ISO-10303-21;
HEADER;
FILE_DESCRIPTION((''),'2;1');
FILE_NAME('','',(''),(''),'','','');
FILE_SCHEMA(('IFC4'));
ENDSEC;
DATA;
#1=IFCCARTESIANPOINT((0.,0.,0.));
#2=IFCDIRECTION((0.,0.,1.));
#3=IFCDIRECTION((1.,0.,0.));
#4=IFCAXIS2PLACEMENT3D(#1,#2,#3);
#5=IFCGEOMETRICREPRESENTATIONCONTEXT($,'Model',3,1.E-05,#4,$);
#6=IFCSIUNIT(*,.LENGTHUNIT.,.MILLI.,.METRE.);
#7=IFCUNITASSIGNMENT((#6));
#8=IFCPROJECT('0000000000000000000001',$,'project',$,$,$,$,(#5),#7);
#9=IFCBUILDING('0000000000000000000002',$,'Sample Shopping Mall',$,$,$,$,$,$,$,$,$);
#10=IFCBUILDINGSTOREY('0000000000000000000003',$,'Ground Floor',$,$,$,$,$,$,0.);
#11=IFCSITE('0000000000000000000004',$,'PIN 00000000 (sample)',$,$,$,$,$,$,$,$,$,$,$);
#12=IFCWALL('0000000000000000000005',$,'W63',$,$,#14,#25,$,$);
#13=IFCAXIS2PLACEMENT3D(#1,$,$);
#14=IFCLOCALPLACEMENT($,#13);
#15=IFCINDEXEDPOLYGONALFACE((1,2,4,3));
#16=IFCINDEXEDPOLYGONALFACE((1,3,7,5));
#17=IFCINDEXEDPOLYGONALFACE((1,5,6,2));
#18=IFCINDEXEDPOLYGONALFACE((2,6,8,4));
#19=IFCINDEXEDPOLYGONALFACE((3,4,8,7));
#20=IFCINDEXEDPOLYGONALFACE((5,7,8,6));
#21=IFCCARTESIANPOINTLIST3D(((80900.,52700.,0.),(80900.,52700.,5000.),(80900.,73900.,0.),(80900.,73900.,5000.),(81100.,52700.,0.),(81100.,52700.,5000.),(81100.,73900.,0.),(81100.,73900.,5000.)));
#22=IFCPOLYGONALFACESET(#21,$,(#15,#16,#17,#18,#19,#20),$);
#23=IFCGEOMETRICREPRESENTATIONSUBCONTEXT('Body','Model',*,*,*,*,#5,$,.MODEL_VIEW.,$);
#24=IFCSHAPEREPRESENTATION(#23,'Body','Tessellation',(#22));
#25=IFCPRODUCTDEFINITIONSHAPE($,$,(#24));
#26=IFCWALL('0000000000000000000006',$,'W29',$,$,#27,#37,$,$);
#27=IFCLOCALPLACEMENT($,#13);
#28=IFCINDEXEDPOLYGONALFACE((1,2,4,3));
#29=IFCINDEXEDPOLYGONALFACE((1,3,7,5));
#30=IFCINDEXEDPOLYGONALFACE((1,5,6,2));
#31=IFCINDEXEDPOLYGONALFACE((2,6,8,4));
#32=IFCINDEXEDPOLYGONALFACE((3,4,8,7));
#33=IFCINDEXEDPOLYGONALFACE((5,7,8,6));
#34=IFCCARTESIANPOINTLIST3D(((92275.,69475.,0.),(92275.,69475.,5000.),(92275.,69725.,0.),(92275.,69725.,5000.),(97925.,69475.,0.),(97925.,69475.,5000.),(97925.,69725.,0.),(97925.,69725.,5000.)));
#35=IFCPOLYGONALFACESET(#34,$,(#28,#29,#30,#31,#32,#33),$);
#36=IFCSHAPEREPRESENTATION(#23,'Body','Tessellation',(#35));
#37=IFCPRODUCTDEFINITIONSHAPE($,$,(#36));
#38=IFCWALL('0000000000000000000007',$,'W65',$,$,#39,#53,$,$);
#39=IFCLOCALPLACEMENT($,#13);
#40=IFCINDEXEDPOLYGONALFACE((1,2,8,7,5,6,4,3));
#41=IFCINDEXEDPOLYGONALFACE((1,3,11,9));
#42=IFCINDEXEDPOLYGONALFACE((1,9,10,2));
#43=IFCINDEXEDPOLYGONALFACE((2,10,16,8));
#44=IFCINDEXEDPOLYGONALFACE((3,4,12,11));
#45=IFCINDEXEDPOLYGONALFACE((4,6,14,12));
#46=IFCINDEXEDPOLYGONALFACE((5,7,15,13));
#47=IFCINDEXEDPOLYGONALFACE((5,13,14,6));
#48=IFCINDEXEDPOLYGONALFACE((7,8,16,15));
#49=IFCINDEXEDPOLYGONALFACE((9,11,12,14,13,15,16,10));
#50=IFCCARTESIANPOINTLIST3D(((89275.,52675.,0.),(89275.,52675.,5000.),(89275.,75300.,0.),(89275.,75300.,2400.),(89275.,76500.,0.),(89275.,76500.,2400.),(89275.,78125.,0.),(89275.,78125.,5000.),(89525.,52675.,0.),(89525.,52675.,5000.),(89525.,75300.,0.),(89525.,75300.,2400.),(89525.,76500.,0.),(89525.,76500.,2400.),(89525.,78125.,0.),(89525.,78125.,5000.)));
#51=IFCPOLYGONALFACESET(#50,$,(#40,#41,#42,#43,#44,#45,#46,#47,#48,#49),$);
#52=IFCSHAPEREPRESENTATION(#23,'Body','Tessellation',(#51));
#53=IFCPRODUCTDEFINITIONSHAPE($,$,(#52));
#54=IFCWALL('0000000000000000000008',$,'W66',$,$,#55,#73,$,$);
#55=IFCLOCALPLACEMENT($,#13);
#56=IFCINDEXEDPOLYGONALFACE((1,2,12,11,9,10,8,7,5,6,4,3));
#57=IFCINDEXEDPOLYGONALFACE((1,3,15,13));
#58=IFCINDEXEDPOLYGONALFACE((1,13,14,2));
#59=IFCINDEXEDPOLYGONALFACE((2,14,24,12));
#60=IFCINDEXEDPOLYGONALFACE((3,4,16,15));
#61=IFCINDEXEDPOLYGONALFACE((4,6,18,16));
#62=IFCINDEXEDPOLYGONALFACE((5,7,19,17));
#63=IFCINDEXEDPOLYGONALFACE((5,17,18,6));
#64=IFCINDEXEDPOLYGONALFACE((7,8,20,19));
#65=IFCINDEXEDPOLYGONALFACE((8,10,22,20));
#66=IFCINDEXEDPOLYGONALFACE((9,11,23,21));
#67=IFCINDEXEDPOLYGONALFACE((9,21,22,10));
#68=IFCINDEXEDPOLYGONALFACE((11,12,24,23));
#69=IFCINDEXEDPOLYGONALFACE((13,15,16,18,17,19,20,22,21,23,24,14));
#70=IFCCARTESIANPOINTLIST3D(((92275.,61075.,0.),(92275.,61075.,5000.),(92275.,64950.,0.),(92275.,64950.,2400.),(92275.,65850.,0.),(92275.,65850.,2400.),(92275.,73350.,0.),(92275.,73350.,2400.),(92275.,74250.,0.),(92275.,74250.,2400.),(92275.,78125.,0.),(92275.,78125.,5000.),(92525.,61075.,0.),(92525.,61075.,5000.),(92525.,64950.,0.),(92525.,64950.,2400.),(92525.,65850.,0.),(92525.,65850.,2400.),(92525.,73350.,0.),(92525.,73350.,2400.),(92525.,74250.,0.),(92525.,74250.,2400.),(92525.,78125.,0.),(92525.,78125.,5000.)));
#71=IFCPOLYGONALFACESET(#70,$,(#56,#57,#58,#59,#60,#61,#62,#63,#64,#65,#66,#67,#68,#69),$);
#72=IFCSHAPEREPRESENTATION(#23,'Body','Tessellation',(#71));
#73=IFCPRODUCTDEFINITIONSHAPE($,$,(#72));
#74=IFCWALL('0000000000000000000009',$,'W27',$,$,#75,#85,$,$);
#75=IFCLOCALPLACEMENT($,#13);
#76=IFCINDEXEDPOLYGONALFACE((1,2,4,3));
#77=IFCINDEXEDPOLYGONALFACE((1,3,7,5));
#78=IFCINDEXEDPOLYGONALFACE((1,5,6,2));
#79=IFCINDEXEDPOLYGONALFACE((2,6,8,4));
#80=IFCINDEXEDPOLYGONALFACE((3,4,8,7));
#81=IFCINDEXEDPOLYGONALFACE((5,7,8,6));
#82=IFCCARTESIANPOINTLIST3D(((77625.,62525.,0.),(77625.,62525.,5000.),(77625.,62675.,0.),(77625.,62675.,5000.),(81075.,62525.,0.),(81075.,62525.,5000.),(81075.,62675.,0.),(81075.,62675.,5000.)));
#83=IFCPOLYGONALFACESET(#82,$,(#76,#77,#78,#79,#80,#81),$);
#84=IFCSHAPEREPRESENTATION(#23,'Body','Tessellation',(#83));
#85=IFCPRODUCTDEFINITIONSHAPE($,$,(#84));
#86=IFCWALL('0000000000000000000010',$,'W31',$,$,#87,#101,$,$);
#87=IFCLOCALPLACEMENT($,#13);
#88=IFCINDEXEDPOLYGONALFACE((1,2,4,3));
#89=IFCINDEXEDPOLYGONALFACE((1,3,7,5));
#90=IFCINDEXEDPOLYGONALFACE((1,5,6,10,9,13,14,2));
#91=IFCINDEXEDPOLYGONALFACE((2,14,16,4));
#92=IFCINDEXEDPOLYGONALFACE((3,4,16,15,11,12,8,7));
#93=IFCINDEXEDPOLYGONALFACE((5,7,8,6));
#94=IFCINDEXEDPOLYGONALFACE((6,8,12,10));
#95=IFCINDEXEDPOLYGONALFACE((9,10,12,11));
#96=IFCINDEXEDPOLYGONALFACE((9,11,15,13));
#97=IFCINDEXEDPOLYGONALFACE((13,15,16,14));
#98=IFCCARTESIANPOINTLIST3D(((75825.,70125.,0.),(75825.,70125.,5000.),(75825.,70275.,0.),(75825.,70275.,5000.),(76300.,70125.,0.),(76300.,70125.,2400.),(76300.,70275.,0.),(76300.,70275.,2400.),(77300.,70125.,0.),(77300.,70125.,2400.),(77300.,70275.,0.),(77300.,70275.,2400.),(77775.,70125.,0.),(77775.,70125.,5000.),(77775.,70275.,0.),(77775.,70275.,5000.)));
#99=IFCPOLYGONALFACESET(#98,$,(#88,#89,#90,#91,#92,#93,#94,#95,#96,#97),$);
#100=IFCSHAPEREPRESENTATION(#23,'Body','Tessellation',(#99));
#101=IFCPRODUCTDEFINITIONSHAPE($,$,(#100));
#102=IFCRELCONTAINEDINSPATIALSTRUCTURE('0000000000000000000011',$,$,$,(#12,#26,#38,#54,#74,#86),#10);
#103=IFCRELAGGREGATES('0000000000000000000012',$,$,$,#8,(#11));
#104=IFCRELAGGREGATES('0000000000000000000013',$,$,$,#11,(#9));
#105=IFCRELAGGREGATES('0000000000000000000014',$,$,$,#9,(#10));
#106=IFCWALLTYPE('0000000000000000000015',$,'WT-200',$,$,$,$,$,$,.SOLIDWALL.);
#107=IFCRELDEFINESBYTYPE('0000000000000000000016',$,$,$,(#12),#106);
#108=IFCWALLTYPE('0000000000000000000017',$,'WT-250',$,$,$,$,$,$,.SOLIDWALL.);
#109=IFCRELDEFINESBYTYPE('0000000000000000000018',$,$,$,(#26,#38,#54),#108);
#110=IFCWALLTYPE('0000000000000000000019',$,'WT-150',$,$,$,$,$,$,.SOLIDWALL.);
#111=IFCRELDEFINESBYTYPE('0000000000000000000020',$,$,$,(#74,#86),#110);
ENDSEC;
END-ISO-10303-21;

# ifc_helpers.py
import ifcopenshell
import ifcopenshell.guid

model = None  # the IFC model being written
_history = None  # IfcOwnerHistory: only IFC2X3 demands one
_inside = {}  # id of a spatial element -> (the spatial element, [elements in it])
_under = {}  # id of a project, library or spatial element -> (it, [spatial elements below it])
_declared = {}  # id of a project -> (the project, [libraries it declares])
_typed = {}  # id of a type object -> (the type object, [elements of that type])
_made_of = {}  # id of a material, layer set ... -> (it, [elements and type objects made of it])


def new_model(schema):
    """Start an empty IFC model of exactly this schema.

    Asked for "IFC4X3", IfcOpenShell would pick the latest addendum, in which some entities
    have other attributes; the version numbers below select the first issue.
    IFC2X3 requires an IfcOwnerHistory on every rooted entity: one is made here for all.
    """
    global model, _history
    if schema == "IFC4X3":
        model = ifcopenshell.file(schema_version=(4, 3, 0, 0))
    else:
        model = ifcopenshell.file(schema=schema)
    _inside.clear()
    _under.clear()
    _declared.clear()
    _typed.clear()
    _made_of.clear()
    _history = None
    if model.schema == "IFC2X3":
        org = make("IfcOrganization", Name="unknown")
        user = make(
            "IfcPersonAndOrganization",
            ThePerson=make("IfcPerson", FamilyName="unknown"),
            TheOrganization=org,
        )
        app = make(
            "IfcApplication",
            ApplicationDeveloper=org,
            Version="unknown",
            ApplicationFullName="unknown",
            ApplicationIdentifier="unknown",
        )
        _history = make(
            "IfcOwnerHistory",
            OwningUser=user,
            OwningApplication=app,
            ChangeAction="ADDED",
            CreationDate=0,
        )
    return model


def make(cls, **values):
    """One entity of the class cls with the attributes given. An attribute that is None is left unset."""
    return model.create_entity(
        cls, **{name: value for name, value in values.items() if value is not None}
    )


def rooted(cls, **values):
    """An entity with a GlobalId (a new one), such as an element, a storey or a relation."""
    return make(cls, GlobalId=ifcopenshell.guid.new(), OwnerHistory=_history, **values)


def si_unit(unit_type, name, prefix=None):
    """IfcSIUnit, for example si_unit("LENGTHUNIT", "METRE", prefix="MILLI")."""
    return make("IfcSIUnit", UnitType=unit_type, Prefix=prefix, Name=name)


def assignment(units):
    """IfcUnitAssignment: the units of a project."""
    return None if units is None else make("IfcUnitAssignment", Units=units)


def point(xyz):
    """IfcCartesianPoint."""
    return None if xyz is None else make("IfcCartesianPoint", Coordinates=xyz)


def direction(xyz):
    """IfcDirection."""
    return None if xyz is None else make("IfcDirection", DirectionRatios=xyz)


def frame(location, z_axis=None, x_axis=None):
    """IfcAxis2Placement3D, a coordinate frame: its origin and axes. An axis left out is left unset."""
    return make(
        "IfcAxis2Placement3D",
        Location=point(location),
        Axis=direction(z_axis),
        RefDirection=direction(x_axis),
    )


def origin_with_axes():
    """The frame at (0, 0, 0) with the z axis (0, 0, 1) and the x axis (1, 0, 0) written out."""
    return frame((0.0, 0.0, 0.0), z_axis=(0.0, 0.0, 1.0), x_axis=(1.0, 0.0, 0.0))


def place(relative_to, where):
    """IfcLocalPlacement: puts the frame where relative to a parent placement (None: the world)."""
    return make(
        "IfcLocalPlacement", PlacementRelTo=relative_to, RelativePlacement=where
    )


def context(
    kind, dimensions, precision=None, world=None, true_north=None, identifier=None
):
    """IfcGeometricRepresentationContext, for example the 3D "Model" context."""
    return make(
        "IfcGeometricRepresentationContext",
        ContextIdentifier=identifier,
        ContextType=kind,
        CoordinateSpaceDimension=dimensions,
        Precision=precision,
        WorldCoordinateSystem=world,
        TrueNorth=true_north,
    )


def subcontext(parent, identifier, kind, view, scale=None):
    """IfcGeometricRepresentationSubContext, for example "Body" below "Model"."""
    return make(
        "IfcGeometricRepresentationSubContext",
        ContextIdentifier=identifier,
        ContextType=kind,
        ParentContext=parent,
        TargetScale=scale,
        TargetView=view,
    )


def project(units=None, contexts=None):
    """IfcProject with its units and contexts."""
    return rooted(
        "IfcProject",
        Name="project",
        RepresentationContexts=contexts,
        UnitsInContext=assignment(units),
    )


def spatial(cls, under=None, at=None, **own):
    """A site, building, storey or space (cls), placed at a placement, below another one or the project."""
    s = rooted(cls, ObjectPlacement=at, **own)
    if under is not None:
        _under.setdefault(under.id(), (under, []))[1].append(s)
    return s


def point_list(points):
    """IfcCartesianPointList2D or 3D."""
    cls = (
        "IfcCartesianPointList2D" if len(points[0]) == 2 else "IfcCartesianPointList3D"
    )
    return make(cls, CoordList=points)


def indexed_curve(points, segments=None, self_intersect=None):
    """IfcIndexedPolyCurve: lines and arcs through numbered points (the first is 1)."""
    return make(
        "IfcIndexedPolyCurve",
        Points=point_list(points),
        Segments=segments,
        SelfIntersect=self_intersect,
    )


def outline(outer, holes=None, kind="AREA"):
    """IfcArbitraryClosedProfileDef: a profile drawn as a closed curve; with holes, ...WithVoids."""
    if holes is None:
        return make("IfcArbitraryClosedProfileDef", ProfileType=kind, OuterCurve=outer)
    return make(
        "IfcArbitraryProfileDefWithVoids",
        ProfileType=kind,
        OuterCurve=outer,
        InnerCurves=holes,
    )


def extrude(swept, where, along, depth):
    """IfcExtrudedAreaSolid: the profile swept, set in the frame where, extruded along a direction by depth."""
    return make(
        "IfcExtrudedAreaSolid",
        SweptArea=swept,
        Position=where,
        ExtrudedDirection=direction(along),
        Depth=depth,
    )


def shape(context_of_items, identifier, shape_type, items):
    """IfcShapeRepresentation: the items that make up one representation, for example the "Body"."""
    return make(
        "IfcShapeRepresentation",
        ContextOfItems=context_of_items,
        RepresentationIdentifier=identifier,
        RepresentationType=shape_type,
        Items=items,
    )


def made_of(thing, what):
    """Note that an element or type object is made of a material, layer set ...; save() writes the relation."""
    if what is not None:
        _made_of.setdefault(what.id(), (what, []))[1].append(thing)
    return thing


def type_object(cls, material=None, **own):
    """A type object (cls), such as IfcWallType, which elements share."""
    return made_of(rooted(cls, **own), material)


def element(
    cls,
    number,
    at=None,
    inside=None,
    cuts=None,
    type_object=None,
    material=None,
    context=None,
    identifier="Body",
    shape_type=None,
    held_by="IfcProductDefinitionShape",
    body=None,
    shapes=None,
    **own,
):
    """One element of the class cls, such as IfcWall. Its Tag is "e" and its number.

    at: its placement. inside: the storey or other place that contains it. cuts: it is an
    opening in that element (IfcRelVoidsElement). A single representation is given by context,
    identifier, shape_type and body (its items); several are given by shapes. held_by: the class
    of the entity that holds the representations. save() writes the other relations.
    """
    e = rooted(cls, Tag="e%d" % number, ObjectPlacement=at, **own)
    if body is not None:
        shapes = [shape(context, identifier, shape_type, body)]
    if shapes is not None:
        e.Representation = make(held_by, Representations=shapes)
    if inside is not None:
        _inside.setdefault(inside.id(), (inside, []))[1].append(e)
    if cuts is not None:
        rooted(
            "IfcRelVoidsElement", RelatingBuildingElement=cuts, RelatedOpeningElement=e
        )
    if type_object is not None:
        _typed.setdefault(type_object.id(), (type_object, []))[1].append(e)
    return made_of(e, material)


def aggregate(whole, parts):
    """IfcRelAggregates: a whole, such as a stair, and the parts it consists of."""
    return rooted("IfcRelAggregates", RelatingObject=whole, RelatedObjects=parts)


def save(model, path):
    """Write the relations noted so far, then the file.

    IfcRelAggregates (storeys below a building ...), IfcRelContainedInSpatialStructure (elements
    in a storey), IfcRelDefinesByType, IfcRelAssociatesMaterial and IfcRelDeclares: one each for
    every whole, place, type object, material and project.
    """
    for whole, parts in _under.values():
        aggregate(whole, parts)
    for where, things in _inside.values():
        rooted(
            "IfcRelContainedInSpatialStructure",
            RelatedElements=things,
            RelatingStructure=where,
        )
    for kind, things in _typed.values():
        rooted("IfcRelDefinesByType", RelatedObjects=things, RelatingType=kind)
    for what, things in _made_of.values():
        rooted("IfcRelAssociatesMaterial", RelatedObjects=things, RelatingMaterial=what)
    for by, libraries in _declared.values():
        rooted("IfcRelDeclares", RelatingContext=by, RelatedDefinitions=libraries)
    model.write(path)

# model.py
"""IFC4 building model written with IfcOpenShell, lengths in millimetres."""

from ifc_helpers import new_model, si_unit, frame, origin_with_axes, place, context, subcontext, project, spatial, indexed_curve, outline, extrude, type_object, element, save


model = new_model("IFC4")

# Units and contexts
model_context = context("Model", 3, precision=1e-05, world=origin_with_axes())
body_context = subcontext(model_context, "Body", "Model", "MODEL_VIEW")
ifc_project = project(units=[si_unit("LENGTHUNIT", "METRE", prefix="MILLI")], contexts=[model_context])

# Site, building, storey
site = spatial("IfcSite", under=ifc_project, Name="PIN 00000000 (sample)")
building = spatial("IfcBuilding", under=site, Name="Sample Shopping Mall")
storey = spatial("IfcBuildingStorey", under=building, Name="Ground Floor", Elevation=0.0)

# Wall
wall_type_1 = type_object("IfcWallType", Name="WT-200", PredefinedType="SOLIDWALL")
wall_1_placement = place(None, frame((81100.0, 52700.0, 0.0), z_axis=(0.0, 0.0, 1.0), x_axis=(0.0, 1.0, 0.0)))
element("IfcWall", 1, at=wall_1_placement, inside=storey, type_object=wall_type_1, Name="W63", context=body_context, shape_type="SweptSolid", body=[
    extrude(outline(indexed_curve([(0.0, 0.0), (0.0, 200.0), (21200.0, 200.0), (21200.0, 0.0), (0.0, 0.0)], self_intersect=False)), origin_with_axes(), (0.0, 0.0, 1.0), 5000.0),
])

# Shared definitions
wall_type_2 = type_object("IfcWallType", Name="WT-250", PredefinedType="SOLIDWALL")

# Wall
wall_2_placement = place(None, frame((92275.0, 69475.0, 0.0), z_axis=(0.0, 0.0, 1.0), x_axis=(1.0, 0.0, 0.0)))
element("IfcWall", 2, at=wall_2_placement, inside=storey, type_object=wall_type_2, Name="W29", context=body_context, shape_type="SweptSolid", body=[
    extrude(outline(indexed_curve([(0.0, 0.0), (0.0, 250.0), (5650.0, 250.0), (5650.0, 0.0), (0.0, 0.0)], self_intersect=False)), origin_with_axes(), (0.0, 0.0, 1.0), 5000.0),
])

# Wall, opening
wall_3_placement = place(None, frame((89525.0, 52675.0, 0.0), z_axis=(0.0, 0.0, 1.0), x_axis=(0.0, 1.0, 0.0)))
wall_3 = element("IfcWall", 3, at=wall_3_placement, inside=storey, type_object=wall_type_2, Name="W65", context=body_context, shape_type="SweptSolid", body=[
    extrude(outline(indexed_curve([(0.0, 0.0), (0.0, 250.0), (25450.0, 250.0), (25450.0, 0.0), (0.0, 0.0)], self_intersect=False)), origin_with_axes(), (0.0, 0.0, 1.0), 5000.0),
])
opening_1_placement = place(wall_3_placement, frame((22625.0, -100.0, 0.0), z_axis=(0.0, 0.0, 1.0), x_axis=(1.0, 0.0, 0.0)))
element("IfcOpeningElement", 4, at=opening_1_placement, cuts=wall_3, context=body_context, shape_type="SweptSolid", body=[
    extrude(outline(indexed_curve([(0.0, 0.0), (0.0, 450.0), (1200.0, 450.0), (1200.0, 0.0), (0.0, 0.0)], self_intersect=False)), origin_with_axes(), (0.0, 0.0, 1.0), 2400.0),
])

# Wall, openings
wall_4_placement = place(None, frame((92525.0, 61075.0, 0.0), z_axis=(0.0, 0.0, 1.0), x_axis=(0.0, 1.0, 0.0)))
wall_4 = element("IfcWall", 5, at=wall_4_placement, inside=storey, type_object=wall_type_2, Name="W66", context=body_context, shape_type="SweptSolid", body=[
    extrude(outline(indexed_curve([(0.0, 0.0), (0.0, 250.0), (17050.0, 250.0), (17050.0, 0.0), (0.0, 0.0)], self_intersect=False)), origin_with_axes(), (0.0, 0.0, 1.0), 5000.0),
])
opening_2_placement = place(wall_4_placement, frame((3875.0, -100.0, 0.0), z_axis=(0.0, 0.0, 1.0), x_axis=(1.0, 0.0, 0.0)))
element("IfcOpeningElement", 6, at=opening_2_placement, cuts=wall_4, context=body_context, shape_type="SweptSolid", body=[
    extrude(outline(indexed_curve([(0.0, 0.0), (0.0, 450.0), (900.0, 450.0), (900.0, 0.0), (0.0, 0.0)], self_intersect=False)), origin_with_axes(), (0.0, 0.0, 1.0), 2400.0),
])
opening_3_placement = place(wall_4_placement, frame((12275.0, -100.0, 0.0), z_axis=(0.0, 0.0, 1.0), x_axis=(1.0, 0.0, 0.0)))
element("IfcOpeningElement", 7, at=opening_3_placement, cuts=wall_4, context=body_context, shape_type="SweptSolid", body=[
    extrude(outline(indexed_curve([(0.0, 0.0), (0.0, 450.0), (900.0, 450.0), (900.0, 0.0), (0.0, 0.0)], self_intersect=False)), origin_with_axes(), (0.0, 0.0, 1.0), 2400.0),
])

# Wall
wall_type_3 = type_object("IfcWallType", Name="WT-150", PredefinedType="SOLIDWALL")
wall_5_placement = place(None, frame((77625.0, 62525.0, 0.0), z_axis=(0.0, 0.0, 1.0), x_axis=(1.0, 0.0, 0.0)))
element("IfcWall", 8, at=wall_5_placement, inside=storey, type_object=wall_type_3, Name="W27", context=body_context, shape_type="SweptSolid", body=[
    extrude(outline(indexed_curve([(0.0, 0.0), (0.0, 150.0), (3450.0, 150.0), (3450.0, 0.0), (0.0, 0.0)], self_intersect=False)), origin_with_axes(), (0.0, 0.0, 1.0), 5000.0),
])

# Wall, opening
wall_6_placement = place(None, frame((75825.0, 70125.0, 0.0), z_axis=(0.0, 0.0, 1.0), x_axis=(1.0, 0.0, 0.0)))
wall_6 = element("IfcWall", 9, at=wall_6_placement, inside=storey, type_object=wall_type_3, Name="W31", context=body_context, shape_type="SweptSolid", body=[
    extrude(outline(indexed_curve([(0.0, 0.0), (0.0, 150.0), (1950.0, 150.0), (1950.0, 0.0), (0.0, 0.0)], self_intersect=False)), origin_with_axes(), (0.0, 0.0, 1.0), 5000.0),
])
opening_4_placement = place(wall_6_placement, frame((475.0, -100.0, 0.0), z_axis=(0.0, 0.0, 1.0), x_axis=(1.0, 0.0, 0.0)))
element("IfcOpeningElement", 10, at=opening_4_placement, cuts=wall_6, context=body_context, shape_type="SweptSolid", body=[
    extrude(outline(indexed_curve([(0.0, 0.0), (0.0, 350.0), (1000.0, 350.0), (1000.0, 0.0), (0.0, 0.0)], self_intersect=False)), origin_with_axes(), (0.0, 0.0, 1.0), 2400.0),
])

save(model, "model.ifc")
